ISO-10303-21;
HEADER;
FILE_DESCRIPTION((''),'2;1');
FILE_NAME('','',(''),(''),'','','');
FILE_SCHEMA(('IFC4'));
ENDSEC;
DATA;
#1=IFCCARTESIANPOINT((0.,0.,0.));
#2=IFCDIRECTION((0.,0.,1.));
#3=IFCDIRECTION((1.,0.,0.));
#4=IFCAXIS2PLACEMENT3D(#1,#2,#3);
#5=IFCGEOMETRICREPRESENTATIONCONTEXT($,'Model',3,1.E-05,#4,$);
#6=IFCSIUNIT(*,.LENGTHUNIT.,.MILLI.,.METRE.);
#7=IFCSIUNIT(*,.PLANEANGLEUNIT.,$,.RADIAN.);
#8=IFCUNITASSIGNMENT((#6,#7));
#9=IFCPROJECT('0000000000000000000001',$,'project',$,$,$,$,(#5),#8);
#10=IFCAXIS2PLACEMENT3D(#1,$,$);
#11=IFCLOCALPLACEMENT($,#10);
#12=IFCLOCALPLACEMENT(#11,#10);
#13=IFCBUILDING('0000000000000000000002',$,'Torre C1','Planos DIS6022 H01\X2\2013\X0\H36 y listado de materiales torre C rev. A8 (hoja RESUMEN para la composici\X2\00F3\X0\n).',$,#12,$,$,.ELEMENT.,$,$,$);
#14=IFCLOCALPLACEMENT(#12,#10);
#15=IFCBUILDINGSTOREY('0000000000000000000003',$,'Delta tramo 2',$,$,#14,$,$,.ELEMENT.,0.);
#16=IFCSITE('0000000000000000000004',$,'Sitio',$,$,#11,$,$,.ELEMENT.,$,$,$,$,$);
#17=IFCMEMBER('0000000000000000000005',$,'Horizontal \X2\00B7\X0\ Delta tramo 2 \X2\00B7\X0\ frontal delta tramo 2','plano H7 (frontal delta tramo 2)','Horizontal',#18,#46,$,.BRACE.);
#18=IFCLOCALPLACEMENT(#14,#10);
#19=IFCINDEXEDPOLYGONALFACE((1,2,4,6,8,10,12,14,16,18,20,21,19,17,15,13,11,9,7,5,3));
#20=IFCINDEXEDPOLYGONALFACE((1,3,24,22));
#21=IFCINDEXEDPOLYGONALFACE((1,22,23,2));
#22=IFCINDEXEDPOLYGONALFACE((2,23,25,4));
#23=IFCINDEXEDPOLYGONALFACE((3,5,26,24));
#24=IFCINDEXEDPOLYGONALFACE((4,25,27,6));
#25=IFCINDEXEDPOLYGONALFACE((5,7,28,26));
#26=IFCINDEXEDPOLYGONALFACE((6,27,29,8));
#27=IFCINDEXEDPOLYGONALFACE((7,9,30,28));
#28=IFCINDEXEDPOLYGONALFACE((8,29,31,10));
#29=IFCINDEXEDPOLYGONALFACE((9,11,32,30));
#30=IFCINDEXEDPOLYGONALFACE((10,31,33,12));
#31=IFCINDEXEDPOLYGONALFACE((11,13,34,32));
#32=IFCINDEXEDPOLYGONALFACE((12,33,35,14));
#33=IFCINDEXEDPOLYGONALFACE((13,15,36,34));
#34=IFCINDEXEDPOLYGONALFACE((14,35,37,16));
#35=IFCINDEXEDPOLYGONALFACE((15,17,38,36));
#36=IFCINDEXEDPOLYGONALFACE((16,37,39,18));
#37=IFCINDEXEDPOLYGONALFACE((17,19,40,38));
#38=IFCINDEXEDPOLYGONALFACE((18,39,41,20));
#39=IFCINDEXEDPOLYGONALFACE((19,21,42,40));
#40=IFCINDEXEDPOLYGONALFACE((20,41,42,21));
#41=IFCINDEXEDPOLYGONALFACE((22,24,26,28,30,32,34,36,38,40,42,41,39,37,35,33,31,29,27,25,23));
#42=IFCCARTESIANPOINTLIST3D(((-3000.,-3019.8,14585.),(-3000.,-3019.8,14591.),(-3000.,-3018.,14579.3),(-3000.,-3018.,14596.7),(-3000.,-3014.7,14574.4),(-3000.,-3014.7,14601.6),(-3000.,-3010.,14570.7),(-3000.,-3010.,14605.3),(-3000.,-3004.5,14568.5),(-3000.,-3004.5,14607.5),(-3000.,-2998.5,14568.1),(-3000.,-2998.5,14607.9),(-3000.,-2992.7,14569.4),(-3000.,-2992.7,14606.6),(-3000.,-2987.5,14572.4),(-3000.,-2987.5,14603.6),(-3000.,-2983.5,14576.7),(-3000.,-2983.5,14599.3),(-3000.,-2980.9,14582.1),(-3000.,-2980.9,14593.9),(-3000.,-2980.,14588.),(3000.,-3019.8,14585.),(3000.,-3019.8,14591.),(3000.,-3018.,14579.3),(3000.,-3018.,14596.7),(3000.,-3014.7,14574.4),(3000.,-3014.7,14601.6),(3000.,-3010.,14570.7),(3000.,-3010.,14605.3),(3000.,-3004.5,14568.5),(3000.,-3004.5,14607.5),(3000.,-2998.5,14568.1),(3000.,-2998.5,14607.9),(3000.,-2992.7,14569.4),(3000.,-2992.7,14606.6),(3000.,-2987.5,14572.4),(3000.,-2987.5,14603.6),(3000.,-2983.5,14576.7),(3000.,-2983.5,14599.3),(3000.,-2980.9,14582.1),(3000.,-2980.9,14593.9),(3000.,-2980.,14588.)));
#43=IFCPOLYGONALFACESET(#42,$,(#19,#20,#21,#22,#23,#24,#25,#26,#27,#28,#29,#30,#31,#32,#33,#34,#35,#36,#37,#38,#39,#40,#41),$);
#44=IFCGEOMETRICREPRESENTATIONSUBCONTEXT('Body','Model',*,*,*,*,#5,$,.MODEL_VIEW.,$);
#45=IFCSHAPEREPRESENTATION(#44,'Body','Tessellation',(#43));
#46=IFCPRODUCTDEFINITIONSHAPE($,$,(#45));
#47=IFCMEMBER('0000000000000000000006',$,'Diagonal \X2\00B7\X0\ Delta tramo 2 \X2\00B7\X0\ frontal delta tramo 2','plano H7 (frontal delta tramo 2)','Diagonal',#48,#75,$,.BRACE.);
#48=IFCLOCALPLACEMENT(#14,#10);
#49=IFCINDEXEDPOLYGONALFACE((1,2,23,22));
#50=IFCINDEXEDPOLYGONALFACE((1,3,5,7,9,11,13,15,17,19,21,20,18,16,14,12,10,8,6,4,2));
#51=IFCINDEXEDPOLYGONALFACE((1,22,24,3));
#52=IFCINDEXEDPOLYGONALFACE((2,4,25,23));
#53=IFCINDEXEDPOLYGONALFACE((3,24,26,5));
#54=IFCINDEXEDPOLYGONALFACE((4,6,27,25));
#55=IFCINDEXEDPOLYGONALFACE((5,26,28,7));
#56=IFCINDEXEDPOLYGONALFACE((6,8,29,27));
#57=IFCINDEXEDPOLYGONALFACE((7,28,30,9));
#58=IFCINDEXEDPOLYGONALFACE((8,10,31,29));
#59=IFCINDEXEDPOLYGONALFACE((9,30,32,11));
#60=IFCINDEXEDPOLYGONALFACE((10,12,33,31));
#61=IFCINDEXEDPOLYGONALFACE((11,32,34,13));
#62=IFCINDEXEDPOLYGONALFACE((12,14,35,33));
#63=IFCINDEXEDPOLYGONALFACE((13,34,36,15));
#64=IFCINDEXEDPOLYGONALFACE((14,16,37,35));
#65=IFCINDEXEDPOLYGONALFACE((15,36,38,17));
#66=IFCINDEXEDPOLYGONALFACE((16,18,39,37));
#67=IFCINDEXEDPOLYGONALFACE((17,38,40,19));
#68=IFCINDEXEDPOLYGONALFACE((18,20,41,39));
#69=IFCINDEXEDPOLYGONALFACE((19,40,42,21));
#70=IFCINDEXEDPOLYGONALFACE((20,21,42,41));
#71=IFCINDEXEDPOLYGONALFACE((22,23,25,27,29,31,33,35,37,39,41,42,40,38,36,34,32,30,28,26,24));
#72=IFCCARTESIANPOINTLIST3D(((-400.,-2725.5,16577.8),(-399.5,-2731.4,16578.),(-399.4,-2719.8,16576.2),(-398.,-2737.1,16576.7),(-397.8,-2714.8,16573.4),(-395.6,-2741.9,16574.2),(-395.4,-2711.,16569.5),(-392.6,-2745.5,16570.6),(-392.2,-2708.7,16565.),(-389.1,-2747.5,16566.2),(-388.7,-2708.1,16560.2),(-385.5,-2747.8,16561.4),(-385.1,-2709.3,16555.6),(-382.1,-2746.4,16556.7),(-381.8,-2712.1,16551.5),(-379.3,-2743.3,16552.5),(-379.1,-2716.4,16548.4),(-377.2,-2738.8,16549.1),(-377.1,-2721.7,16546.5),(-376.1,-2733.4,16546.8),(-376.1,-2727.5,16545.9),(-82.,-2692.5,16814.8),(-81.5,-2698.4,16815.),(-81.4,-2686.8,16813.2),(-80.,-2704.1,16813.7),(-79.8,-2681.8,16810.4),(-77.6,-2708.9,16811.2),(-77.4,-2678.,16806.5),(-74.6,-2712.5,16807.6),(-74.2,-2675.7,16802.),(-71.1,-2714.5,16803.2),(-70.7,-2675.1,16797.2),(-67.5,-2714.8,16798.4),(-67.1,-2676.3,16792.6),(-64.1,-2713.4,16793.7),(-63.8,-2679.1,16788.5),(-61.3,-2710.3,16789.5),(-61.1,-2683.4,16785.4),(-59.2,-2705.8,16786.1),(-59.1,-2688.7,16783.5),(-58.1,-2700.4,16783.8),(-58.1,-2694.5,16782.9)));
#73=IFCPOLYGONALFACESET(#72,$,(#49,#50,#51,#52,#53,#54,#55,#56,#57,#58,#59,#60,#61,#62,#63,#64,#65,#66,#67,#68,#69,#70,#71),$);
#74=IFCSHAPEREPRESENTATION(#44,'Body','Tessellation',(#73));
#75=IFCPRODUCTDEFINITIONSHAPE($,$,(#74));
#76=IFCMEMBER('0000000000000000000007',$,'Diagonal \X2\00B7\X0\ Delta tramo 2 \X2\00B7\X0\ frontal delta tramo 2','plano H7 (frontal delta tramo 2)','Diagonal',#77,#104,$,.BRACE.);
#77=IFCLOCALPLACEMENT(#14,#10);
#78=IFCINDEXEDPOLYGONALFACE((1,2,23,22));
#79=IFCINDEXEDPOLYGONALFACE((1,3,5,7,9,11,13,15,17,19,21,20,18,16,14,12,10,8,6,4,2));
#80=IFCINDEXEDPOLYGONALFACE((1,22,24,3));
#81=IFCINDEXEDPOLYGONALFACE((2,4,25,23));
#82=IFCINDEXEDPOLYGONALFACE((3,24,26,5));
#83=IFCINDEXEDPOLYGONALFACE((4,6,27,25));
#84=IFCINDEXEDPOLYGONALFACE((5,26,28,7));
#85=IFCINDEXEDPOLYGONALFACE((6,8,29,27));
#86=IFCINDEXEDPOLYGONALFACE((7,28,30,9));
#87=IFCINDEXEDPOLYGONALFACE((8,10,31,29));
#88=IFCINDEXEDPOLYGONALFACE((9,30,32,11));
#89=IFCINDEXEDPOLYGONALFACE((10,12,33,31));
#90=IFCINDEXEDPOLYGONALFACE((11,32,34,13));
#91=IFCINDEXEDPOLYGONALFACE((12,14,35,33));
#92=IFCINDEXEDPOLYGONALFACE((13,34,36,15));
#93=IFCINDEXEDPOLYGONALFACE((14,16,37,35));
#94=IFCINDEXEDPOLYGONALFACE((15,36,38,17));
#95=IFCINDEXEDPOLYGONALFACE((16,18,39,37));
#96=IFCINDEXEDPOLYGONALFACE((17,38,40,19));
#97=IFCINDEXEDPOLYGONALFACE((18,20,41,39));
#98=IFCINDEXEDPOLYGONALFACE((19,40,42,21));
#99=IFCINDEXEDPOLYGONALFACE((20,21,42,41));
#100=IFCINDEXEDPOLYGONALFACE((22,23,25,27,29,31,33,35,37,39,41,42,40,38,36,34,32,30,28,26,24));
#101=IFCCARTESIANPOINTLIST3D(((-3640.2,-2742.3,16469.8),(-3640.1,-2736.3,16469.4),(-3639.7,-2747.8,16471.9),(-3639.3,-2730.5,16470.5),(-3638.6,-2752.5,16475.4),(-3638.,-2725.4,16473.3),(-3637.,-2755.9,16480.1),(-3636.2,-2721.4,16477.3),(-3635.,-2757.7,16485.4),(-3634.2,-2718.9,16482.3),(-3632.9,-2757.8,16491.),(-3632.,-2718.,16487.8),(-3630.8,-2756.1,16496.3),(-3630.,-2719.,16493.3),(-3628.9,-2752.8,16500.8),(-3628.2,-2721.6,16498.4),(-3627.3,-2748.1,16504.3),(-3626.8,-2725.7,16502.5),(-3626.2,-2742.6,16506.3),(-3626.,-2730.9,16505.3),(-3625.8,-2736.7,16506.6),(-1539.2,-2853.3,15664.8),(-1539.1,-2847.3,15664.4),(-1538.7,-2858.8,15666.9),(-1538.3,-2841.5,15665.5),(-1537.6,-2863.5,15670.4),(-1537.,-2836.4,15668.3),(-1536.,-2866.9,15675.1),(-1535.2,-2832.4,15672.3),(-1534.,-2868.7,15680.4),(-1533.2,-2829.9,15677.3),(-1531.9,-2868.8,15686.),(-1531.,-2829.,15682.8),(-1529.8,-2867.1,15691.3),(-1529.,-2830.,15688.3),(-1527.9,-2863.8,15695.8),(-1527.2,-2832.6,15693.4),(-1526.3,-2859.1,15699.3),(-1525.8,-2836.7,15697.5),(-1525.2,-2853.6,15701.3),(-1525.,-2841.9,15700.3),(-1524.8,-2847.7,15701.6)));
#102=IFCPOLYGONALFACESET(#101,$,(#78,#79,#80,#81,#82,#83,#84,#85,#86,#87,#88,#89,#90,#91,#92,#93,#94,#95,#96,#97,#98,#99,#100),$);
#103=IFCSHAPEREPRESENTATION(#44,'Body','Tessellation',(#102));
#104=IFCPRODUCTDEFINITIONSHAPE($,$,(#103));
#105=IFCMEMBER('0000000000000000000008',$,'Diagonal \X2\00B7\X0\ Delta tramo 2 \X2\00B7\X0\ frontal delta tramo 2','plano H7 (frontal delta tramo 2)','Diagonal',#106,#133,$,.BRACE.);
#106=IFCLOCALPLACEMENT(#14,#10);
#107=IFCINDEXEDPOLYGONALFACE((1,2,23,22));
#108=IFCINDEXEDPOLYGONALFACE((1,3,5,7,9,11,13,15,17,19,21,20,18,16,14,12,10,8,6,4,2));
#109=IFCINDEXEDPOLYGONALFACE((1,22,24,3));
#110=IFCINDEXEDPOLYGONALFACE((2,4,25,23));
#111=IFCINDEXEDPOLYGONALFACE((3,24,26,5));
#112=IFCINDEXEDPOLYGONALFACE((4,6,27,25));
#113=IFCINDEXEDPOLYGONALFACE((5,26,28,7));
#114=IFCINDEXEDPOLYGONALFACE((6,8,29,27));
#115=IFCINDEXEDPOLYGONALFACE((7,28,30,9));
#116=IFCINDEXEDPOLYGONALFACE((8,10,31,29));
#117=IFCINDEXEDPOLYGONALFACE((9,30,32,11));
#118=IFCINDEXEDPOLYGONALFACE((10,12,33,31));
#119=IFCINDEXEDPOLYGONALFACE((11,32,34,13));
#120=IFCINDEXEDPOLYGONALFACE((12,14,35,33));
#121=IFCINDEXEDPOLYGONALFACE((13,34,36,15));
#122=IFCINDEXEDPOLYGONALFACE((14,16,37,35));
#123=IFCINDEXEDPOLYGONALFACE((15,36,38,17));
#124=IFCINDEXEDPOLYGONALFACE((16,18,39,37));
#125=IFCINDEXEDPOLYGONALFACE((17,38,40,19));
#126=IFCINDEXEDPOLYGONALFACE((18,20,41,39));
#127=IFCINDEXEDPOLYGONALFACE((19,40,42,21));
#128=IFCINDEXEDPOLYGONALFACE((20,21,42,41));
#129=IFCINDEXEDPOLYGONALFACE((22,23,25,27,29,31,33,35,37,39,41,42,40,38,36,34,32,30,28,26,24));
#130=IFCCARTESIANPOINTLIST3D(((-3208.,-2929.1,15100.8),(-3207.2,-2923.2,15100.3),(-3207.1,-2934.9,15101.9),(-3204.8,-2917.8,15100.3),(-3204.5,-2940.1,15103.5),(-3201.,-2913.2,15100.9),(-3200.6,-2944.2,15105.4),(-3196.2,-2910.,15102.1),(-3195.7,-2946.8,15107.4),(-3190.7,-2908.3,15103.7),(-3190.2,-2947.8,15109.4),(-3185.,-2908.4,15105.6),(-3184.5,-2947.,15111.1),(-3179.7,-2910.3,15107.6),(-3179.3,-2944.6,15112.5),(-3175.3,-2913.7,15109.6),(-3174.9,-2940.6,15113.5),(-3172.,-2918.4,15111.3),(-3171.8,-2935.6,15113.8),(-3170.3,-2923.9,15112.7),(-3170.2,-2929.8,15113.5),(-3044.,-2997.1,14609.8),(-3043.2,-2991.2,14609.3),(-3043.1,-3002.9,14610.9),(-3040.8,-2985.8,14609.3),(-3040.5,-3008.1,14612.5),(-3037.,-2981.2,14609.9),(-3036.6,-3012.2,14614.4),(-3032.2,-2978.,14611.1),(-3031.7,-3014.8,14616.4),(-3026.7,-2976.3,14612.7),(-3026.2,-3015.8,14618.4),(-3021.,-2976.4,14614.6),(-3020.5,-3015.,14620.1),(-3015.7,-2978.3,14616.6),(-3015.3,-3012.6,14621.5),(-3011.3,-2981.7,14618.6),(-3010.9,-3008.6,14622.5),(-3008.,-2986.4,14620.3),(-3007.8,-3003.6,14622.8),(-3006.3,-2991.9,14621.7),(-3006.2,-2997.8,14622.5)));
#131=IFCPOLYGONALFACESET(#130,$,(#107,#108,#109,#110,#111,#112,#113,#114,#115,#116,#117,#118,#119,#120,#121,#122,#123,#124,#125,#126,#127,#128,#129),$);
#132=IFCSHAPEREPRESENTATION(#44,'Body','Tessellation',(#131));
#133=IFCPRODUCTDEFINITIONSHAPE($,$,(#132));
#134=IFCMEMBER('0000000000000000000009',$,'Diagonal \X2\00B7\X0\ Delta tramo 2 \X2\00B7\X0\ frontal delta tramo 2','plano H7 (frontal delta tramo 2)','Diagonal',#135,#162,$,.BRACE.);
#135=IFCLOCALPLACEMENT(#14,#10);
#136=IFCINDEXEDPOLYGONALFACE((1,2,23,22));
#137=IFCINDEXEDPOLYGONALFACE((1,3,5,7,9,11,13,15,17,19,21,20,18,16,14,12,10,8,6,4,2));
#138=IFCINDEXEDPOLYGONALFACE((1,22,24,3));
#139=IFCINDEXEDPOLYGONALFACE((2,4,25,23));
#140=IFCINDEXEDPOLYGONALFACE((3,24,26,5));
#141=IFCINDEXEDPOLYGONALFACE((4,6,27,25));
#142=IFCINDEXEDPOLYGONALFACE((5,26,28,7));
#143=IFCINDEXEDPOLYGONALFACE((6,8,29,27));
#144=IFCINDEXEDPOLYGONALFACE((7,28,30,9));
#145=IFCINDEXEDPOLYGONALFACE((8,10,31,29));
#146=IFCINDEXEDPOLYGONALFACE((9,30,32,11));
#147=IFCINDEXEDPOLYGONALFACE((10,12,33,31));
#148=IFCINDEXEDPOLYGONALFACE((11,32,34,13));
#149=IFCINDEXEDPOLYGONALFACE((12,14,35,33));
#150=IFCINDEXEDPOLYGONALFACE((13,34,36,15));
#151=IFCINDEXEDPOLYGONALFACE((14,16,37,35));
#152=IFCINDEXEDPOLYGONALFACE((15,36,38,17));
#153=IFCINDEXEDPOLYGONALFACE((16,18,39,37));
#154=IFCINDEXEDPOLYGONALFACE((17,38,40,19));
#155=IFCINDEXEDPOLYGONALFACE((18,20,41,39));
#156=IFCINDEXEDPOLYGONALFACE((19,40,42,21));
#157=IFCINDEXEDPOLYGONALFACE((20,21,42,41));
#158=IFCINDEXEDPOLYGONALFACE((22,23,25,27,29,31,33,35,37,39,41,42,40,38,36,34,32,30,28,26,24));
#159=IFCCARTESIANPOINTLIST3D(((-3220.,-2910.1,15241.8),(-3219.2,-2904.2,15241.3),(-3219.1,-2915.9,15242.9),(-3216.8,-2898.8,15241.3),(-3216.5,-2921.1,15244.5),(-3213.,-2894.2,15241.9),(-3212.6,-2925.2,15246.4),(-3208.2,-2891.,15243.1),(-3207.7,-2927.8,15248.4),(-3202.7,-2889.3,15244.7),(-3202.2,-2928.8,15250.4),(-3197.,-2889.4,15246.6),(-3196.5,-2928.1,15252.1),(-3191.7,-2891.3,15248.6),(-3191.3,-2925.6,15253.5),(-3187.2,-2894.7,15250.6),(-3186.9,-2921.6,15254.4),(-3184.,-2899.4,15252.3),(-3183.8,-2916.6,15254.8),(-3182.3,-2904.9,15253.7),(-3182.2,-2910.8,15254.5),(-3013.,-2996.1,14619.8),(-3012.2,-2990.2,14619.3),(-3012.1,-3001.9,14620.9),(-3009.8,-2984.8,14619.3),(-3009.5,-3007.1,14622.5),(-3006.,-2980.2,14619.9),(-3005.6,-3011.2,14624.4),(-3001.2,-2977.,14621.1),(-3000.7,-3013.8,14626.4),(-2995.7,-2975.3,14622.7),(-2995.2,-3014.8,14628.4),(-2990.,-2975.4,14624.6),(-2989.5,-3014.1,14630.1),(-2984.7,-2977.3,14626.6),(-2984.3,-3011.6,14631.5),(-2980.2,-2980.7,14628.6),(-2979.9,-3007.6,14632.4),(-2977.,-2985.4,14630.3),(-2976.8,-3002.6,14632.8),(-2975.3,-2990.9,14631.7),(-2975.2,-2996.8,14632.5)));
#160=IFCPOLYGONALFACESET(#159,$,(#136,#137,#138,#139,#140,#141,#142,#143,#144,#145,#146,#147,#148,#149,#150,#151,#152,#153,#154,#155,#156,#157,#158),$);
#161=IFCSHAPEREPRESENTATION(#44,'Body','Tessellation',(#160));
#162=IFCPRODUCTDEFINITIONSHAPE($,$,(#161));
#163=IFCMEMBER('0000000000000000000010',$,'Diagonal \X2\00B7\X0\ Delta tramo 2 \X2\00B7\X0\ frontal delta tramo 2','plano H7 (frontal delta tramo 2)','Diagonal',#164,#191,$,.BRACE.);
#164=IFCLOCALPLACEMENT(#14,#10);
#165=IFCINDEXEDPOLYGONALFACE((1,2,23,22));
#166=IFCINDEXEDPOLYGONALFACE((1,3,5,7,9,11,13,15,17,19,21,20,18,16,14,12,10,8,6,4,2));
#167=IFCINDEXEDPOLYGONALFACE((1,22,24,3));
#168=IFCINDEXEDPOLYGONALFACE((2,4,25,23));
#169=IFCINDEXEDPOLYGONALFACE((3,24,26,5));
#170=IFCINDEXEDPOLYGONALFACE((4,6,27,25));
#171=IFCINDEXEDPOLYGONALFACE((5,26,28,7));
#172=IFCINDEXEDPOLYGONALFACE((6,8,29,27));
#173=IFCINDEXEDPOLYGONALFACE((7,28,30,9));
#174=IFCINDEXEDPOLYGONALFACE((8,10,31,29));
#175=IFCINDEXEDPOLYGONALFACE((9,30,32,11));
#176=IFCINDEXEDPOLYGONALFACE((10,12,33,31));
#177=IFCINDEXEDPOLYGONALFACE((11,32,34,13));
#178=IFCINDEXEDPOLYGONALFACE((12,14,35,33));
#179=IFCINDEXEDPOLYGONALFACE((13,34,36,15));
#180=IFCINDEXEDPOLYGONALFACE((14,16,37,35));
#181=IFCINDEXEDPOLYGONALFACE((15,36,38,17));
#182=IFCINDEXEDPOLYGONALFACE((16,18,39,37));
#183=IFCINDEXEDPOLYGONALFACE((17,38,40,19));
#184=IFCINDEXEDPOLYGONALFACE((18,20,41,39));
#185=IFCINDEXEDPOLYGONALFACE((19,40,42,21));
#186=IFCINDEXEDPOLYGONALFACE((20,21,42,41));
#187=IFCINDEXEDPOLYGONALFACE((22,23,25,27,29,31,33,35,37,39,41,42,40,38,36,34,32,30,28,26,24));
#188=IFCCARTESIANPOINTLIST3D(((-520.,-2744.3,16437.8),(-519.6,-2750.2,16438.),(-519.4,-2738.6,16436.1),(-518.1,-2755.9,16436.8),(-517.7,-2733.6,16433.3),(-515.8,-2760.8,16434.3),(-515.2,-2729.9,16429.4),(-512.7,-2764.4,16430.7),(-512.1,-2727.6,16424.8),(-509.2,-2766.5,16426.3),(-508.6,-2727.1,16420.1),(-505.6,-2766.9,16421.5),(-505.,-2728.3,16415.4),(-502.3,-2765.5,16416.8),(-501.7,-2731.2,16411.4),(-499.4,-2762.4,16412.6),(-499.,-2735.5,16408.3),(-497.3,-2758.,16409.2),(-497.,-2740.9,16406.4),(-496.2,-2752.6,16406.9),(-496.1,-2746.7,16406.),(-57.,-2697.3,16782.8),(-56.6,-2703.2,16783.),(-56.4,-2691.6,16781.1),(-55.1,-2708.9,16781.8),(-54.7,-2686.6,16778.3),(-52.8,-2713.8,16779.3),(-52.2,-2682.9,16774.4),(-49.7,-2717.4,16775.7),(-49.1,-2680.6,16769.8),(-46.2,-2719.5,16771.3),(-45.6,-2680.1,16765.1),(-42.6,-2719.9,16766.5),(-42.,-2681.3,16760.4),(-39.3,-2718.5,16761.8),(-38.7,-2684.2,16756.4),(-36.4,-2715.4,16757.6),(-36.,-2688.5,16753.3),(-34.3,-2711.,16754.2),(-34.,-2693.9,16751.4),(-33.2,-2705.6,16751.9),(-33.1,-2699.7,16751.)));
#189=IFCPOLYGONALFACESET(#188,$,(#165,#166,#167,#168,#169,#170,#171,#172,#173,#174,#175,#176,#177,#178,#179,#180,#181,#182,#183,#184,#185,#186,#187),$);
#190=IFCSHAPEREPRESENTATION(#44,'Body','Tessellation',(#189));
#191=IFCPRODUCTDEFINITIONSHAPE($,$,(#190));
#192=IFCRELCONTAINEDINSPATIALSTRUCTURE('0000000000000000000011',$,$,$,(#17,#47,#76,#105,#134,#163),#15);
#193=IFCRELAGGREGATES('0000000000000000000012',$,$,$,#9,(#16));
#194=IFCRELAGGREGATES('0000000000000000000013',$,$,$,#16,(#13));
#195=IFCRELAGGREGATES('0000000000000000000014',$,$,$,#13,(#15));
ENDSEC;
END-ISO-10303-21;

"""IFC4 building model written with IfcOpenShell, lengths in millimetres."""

from ifc_helpers import new_model, si_unit, frame, origin, origin_with_axes, place, context, subcontext, project, spatial, circle, extrude, element, save


model = new_model("IFC4")

# Units and contexts
model_context = context("Model", 3, precision=1e-05, world=origin_with_axes())
body_context = subcontext(model_context, "Body", "Model", "MODEL_VIEW")
ifc_project = project(units=[si_unit("LENGTHUNIT", "METRE", prefix="MILLI"), si_unit("PLANEANGLEUNIT", "RADIAN")], contexts=[model_context])

# Site, building, storey
site_placement = place(None, origin())
site = spatial("IfcSite", under=ifc_project, at=site_placement, Name="Sitio", CompositionType="ELEMENT")
building_placement = place(site_placement, origin())
building = spatial("IfcBuilding", under=site, at=building_placement, Name="Torre C1", Description="Planos DIS6022 H01–H36 y listado de materiales torre C rev. A8 (hoja RESUMEN para la composición).", CompositionType="ELEMENT")
storey_placement = place(building_placement, origin())
storey = spatial("IfcBuildingStorey", under=building, at=storey_placement, Name="Delta tramo 2", CompositionType="ELEMENT", Elevation=0.0)

# Members
member_1_placement = place(storey_placement, frame((-3000.0, -3000.0, 14588.0), z_axis=(1.0, 0.0, 0.0), x_axis=(0.0, 1.0, 0.0)))
element("IfcMember", 1, at=member_1_placement, inside=storey, Name="Horizontal · Delta tramo 2 · frontal delta tramo 2", Description="plano H7 (frontal delta tramo 2)", ObjectType="Horizontal", PredefinedType="BRACE", context=body_context, shape_type="SweptSolid", body=[
    extrude(circle(Radius=20.0), None, (0.0, 0.0, 1.0), 6000.0),
])
member_2_placement = place(storey_placement, frame((-70.0, -2695.0, 16799.0), z_axis=(-0.79905, -0.08292, -0.595519), x_axis=(-0.036005, 0.995266, -0.09027)))
element("IfcMember", 2, at=member_2_placement, inside=storey, Name="Diagonal · Delta tramo 2 · frontal delta tramo 2", Description="plano H7 (frontal delta tramo 2)", ObjectType="Diagonal", PredefinedType="BRACE", context=body_context, shape_type="SweptSolid", body=[
    extrude(circle(Radius=20.0), None, (0.0, 0.0, 1.0), 398.0),
])
member_3_placement = place(storey_placement, frame((-1532.0, -2849.0, 15683.0), z_axis=(-0.932669, 0.049275, 0.357353), x_axis=(0.152168, 0.951918, 0.26589)))
element("IfcMember", 3, at=member_3_placement, inside=storey, Name="Diagonal · Delta tramo 2 · frontal delta tramo 2", Description="plano H7 (frontal delta tramo 2)", ObjectType="Diagonal", PredefinedType="BRACE", context=body_context, shape_type="SweptSolid", body=[
    extrude(circle(Radius=20.0), None, (0.0, 0.0, 1.0), 2252.7),
])
member_4_placement = place(storey_placement, frame((-3025.0, -2996.0, 14616.0), z_axis=(-0.314109, 0.13024, 0.940411), x_axis=(0.687135, 0.714708, 0.130529)))
element("IfcMember", 4, at=member_4_placement, inside=storey, Name="Diagonal · Delta tramo 2 · frontal delta tramo 2", Description="plano H7 (frontal delta tramo 2)", ObjectType="Diagonal", PredefinedType="BRACE", context=body_context, shape_type="SweptSolid", body=[
    extrude(circle(Radius=20.0), None, (0.0, 0.0, 1.0), 522.1),
])
member_5_placement = place(storey_placement, frame((-2994.0, -2995.0, 14626.0), z_axis=(-0.313087, 0.130075, 0.940775), x_axis=(0.687514, 0.714436, 0.130023)))
element("IfcMember", 5, at=member_5_placement, inside=storey, Name="Diagonal · Delta tramo 2 · frontal delta tramo 2", Description="plano H7 (frontal delta tramo 2)", ObjectType="Diagonal", PredefinedType="BRACE", context=body_context, shape_type="SweptSolid", body=[
    extrude(circle(Radius=20.0), None, (0.0, 0.0, 1.0), 661.2),
])
member_6_placement = place(storey_placement, frame((-45.0, -2700.0, 16767.0), z_axis=(-0.799223, -0.081131, -0.595533), x_axis=(-0.028395, 0.994838, -0.097421)))
element("IfcMember", 6, at=member_6_placement, inside=storey, Name="Diagonal · Delta tramo 2 · frontal delta tramo 2", Description="plano H7 (frontal delta tramo 2)", ObjectType="Diagonal", PredefinedType="BRACE", context=body_context, shape_type="SweptSolid", body=[
    extrude(circle(Radius=20.0), None, (0.0, 0.0, 1.0), 579.3),
])

save(model, "model.ifc")
